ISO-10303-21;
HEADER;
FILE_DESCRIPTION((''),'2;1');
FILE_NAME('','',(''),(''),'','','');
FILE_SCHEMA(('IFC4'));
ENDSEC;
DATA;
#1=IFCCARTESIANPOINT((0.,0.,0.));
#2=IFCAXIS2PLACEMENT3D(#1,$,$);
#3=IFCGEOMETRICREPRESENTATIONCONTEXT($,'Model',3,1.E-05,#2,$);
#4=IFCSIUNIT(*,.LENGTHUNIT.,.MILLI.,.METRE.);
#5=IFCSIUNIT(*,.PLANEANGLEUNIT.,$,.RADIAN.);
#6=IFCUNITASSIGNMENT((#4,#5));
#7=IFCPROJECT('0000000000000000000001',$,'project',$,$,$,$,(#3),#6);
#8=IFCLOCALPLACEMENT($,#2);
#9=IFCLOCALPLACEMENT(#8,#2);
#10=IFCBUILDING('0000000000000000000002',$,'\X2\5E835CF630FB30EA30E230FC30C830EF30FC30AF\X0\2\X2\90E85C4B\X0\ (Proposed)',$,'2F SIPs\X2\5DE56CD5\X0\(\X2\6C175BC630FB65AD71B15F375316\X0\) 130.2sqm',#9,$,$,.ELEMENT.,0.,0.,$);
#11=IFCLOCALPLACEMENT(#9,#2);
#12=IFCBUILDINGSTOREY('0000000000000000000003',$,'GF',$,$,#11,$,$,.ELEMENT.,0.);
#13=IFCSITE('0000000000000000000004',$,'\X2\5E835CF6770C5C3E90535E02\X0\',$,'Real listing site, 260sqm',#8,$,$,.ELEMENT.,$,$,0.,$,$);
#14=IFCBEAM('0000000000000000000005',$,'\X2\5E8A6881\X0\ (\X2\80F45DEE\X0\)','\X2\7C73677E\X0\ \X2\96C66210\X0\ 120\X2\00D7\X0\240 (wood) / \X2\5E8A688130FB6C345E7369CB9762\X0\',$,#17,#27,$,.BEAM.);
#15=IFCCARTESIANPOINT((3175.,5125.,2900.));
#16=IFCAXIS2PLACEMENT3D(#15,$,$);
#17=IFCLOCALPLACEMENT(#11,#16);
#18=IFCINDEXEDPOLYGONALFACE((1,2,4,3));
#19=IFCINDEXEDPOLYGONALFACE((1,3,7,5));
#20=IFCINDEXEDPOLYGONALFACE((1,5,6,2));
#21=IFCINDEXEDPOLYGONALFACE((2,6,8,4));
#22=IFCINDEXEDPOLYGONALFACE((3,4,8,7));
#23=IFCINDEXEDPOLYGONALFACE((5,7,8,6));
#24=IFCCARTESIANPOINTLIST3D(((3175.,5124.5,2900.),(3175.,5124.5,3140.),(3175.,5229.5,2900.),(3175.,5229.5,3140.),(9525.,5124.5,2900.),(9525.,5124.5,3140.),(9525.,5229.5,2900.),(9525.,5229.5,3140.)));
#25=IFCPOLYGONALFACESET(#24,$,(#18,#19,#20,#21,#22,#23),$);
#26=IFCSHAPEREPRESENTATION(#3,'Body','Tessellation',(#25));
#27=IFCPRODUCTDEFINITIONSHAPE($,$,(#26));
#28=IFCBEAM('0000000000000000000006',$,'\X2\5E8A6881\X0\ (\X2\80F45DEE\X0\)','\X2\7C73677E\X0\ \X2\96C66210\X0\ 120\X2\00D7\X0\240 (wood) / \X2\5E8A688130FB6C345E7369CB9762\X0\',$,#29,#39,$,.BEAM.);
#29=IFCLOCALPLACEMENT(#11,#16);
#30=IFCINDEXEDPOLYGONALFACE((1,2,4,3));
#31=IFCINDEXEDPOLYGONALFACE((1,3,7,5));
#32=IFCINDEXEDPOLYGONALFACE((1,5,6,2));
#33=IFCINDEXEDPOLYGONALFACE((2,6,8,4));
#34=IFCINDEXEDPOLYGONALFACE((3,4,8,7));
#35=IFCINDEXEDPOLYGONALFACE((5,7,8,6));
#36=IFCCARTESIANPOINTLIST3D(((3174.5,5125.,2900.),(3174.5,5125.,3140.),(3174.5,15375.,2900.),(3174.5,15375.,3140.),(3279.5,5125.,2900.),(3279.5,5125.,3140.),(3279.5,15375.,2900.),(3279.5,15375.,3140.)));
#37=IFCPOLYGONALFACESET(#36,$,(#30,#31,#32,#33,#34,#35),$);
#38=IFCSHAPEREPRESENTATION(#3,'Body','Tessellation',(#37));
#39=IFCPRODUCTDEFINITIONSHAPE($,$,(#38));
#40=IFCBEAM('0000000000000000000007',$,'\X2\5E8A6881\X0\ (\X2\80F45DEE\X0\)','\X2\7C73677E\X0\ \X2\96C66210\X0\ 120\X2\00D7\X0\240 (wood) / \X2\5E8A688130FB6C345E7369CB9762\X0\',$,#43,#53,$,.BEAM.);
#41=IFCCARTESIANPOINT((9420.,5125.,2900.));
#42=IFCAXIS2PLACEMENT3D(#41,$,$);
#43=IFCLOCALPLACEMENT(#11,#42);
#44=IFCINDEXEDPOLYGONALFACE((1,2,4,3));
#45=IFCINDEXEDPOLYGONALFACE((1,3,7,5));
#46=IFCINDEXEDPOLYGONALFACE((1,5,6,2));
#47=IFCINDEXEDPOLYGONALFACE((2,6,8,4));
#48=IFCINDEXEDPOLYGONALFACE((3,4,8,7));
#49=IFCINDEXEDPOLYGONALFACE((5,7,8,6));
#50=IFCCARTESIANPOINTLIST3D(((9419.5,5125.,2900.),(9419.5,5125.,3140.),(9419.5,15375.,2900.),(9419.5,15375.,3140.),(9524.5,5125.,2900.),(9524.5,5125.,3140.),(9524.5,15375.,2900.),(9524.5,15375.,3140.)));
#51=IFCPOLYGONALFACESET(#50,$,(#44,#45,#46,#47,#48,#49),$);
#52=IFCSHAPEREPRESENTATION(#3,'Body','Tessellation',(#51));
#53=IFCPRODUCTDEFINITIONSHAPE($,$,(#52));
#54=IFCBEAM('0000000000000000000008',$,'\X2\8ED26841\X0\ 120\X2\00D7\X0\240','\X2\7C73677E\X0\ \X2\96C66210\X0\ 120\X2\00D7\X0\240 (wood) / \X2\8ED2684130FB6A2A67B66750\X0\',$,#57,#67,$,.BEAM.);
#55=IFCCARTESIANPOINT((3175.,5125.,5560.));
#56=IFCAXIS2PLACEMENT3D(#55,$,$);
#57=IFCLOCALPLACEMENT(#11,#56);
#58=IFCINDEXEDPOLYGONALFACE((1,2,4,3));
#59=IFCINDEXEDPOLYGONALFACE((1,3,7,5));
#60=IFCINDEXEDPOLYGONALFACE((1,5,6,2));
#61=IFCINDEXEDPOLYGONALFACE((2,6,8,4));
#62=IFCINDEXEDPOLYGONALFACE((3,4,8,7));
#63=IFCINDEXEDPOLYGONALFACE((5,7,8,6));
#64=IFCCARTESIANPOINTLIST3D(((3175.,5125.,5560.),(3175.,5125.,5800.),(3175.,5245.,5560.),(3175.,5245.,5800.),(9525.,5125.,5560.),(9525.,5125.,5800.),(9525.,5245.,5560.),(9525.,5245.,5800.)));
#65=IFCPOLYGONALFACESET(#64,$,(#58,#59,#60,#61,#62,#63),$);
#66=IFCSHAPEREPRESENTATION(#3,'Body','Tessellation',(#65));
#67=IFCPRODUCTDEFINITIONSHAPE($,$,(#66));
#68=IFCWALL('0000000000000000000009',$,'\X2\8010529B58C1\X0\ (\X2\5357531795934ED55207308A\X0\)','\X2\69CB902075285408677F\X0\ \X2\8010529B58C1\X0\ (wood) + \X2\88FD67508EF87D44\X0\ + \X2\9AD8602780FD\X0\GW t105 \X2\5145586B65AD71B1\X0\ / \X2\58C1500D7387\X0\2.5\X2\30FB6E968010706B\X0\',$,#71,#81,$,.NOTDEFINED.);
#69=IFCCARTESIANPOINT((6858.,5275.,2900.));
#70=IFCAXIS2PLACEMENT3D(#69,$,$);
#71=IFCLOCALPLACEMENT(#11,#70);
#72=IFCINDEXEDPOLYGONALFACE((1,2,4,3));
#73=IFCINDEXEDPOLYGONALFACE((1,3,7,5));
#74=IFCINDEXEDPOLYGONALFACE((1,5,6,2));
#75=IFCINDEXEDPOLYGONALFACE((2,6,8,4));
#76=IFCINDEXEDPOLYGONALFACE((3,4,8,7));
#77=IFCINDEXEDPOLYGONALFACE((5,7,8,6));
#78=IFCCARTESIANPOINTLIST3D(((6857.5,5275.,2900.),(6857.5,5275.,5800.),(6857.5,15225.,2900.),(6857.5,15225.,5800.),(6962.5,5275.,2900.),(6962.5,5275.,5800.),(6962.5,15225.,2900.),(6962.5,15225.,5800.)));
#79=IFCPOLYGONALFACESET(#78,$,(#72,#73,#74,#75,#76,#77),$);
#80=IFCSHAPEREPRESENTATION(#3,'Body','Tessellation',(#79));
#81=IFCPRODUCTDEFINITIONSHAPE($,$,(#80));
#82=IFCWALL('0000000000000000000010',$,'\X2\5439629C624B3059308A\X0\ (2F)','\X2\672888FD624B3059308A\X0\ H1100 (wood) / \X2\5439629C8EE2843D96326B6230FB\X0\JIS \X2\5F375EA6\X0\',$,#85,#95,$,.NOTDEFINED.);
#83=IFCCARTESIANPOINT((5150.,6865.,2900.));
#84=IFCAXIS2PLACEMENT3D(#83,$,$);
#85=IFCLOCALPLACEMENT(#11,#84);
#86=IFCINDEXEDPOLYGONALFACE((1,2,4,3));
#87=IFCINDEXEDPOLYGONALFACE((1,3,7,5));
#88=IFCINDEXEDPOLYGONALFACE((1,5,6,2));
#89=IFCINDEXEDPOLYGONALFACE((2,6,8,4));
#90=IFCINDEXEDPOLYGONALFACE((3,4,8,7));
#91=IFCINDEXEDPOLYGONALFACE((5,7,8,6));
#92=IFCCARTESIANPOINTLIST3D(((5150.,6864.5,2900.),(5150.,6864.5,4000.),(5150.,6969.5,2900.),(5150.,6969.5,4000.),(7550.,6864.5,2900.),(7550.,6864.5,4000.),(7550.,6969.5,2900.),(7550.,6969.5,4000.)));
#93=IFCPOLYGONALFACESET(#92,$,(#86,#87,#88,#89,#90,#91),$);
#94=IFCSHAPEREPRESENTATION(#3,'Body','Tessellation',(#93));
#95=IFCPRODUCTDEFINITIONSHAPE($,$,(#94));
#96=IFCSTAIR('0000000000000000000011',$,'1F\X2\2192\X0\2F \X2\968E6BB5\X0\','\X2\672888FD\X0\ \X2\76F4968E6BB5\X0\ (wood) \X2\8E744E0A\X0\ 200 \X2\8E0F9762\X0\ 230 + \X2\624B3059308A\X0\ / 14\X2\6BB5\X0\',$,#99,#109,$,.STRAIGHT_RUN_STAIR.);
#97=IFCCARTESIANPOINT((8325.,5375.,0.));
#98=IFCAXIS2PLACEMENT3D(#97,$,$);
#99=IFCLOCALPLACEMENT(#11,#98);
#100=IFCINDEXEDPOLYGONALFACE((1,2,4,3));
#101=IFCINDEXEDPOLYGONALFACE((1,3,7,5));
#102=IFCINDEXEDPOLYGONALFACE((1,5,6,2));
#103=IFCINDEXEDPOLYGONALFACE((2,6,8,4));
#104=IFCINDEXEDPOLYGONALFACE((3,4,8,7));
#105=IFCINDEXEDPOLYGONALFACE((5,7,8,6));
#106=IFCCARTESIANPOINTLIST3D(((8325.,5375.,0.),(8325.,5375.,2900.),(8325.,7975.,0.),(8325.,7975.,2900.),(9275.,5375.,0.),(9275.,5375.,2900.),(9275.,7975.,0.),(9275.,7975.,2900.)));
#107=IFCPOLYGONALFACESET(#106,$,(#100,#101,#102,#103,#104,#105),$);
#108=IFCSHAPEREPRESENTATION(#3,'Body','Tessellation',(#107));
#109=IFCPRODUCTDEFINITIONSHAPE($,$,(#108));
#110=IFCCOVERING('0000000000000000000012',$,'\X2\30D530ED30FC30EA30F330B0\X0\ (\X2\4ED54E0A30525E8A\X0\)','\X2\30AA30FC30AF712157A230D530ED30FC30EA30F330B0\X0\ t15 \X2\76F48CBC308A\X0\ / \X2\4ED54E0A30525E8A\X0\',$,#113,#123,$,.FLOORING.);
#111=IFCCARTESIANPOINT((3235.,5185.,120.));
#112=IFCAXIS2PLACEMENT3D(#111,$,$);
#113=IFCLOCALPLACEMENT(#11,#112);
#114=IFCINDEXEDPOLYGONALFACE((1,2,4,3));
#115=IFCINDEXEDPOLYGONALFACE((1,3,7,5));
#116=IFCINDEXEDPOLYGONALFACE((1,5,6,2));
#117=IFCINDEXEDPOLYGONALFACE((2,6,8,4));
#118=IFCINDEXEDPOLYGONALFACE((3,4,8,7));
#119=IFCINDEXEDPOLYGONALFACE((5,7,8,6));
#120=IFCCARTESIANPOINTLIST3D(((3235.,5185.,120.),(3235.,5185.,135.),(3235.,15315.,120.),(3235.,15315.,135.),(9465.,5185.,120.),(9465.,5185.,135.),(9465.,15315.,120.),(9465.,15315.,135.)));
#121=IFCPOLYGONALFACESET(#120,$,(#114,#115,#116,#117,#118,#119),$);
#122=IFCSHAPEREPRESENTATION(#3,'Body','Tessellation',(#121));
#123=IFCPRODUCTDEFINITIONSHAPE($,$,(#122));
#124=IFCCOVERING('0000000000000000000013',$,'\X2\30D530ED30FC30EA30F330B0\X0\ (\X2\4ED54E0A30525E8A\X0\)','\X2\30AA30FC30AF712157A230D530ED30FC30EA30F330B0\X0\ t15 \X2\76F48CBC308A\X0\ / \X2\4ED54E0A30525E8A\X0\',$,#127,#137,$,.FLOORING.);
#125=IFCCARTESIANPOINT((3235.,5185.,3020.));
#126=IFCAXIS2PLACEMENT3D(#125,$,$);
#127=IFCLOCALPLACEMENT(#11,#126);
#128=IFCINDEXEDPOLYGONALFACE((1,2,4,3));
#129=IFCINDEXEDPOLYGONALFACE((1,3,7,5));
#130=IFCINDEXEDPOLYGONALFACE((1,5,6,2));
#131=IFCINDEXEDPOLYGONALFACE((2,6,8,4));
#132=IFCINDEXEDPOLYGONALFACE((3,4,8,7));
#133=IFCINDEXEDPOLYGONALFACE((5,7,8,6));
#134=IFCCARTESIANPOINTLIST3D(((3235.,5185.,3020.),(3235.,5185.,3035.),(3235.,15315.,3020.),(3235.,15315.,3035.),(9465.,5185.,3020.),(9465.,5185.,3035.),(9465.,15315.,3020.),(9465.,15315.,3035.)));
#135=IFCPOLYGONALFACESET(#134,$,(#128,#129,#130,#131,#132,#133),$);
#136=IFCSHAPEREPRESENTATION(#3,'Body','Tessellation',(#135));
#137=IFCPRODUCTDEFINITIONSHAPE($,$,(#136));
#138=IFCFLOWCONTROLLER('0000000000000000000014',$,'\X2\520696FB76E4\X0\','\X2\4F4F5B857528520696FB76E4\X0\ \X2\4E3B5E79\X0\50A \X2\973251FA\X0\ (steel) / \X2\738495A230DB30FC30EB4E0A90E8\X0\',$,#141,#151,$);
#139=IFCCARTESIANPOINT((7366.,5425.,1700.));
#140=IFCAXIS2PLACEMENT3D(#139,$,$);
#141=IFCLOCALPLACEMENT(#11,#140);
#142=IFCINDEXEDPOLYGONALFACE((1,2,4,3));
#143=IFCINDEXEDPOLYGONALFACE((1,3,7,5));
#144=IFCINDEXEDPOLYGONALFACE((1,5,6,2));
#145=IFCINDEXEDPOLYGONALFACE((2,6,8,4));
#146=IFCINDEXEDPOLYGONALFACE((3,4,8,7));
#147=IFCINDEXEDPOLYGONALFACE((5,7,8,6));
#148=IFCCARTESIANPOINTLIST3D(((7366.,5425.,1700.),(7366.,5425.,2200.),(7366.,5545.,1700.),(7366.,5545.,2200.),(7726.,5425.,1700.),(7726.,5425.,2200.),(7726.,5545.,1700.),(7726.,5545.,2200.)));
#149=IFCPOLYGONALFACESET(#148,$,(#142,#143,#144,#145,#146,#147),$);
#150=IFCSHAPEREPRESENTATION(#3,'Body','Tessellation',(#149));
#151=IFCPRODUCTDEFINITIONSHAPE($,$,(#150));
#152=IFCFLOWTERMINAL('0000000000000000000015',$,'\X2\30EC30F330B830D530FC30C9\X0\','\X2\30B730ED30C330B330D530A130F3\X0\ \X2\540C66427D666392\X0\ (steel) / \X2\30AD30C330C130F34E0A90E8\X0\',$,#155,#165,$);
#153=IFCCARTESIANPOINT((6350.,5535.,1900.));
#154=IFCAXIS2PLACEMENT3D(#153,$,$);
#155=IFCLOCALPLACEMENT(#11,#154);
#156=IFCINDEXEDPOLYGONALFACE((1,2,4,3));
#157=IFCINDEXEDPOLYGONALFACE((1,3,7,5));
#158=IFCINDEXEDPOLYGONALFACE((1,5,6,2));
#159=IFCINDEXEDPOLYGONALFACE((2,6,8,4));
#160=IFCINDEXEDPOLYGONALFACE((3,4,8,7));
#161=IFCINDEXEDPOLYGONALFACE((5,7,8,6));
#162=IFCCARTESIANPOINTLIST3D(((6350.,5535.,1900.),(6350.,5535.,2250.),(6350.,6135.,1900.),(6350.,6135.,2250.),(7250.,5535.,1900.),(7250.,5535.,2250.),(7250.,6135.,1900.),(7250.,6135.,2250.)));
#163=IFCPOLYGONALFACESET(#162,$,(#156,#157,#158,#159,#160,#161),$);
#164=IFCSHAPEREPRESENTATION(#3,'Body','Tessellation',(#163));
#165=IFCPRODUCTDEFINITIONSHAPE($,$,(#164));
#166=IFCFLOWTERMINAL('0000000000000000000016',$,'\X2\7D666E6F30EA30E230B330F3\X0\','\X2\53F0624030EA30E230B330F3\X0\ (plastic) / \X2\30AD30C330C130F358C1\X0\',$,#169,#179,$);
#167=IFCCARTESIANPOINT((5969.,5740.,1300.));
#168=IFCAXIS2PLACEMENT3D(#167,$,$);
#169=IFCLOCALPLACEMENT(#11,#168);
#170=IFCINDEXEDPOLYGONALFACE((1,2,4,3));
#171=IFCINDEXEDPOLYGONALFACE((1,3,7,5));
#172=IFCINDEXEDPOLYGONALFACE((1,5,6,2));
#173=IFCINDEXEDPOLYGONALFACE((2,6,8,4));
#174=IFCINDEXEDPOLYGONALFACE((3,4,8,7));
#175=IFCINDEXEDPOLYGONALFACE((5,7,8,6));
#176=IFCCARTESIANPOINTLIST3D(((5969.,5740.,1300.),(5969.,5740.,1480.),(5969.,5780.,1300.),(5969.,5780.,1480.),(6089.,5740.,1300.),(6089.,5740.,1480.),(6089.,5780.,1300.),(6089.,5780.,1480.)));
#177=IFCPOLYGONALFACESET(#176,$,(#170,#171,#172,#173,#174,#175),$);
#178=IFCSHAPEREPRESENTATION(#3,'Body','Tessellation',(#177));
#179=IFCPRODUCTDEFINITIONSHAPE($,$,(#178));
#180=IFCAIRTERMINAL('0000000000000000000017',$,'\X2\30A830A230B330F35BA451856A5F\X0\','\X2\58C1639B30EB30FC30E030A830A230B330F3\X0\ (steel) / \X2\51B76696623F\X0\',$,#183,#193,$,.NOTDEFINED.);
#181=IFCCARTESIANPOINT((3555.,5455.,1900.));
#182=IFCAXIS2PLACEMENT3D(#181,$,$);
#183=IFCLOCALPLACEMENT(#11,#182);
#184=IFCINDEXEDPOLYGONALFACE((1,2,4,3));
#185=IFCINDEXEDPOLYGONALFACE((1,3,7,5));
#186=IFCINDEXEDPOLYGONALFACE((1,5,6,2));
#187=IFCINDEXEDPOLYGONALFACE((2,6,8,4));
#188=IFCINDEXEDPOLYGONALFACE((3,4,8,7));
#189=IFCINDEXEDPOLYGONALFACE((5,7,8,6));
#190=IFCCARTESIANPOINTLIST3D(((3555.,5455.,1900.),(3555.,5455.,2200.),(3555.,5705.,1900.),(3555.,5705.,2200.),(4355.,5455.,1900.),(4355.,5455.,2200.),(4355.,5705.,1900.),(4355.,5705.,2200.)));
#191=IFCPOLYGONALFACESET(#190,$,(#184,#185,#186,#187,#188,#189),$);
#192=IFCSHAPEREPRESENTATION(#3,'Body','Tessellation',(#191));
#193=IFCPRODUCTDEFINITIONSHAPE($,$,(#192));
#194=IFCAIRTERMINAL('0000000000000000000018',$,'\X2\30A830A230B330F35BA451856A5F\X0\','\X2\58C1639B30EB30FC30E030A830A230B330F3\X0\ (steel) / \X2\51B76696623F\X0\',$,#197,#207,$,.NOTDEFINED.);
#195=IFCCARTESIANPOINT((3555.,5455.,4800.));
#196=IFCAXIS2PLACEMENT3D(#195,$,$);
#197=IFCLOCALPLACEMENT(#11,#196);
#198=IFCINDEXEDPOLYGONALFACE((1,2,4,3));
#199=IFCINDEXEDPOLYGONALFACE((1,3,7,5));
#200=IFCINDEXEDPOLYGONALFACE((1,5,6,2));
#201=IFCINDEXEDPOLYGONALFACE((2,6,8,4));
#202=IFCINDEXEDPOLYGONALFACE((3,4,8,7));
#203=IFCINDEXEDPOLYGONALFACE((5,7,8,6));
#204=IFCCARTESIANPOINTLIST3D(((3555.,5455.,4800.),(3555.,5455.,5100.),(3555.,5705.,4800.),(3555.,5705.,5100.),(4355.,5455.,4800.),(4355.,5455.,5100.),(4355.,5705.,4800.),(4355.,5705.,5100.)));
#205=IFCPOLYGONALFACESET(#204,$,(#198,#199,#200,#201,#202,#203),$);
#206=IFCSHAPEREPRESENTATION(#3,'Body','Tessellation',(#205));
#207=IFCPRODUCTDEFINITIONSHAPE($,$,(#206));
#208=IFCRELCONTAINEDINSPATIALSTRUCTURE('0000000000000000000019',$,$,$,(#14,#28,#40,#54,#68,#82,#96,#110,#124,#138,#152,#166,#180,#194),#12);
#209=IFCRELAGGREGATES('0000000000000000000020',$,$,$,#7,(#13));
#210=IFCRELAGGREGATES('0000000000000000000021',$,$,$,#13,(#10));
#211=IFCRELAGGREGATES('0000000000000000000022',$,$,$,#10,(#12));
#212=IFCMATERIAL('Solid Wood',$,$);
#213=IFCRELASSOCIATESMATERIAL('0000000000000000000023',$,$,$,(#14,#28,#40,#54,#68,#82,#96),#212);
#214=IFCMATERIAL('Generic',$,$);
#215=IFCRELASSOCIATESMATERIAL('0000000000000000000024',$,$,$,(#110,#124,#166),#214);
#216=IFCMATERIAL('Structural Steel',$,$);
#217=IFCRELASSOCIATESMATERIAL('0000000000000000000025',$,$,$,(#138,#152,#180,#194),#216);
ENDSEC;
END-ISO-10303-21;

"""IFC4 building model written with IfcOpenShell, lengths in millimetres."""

from ifc_helpers import new_model, si_unit, frame, frame_2d, origin, place, context, project, spatial, rectangle, extrude, material, element, save


model = new_model("IFC4")

# Units and contexts
model_context = context("Model", 3, precision=1e-05, world=origin())
ifc_project = project(units=[si_unit("LENGTHUNIT", "METRE", prefix="MILLI"), si_unit("PLANEANGLEUNIT", "RADIAN")], contexts=[model_context])

# Site, building, storey
site_placement = place(None, origin())
site = spatial("IfcSite", under=ifc_project, at=site_placement, Name="広島県尾道市", ObjectType="Real listing site, 260sqm", CompositionType="ELEMENT", RefElevation=0.0)
building_placement = place(site_placement, origin())
building = spatial("IfcBuilding", under=site, at=building_placement, Name="広島・リモートワーク2部屋 (Proposed)", ObjectType="2F SIPs工法(気密・断熱強化) 130.2sqm", CompositionType="ELEMENT", ElevationOfRefHeight=0.0, ElevationOfTerrain=0.0)
storey_placement = place(building_placement, origin())
storey = spatial("IfcBuildingStorey", under=building, at=storey_placement, Name="GF", CompositionType="ELEMENT", Elevation=0.0)

# Shared definitions
ifc_material_1 = material(Name="Solid Wood")

# Beams
beam_1_placement = place(storey_placement, frame((3175.0, 5125.0, 2900.0)))
element("IfcBeam", 1, at=beam_1_placement, inside=storey, material=ifc_material_1, Name="床梁 (胴差)", Description="米松 集成 120×240 (wood) / 床梁・水平構面", PredefinedType="BEAM", context=model_context, shape_type="SweptSolid", body=[
    extrude(rectangle(XDim=6350.0, YDim=105.0, at=frame_2d((3175.0, 52.0))), frame((3175.0, 5125.0, 2900.0)), (0.0, 0.0, 1.0), 240.0),
])
beam_2_placement = place(storey_placement, frame((3175.0, 5125.0, 2900.0)))
element("IfcBeam", 2, at=beam_2_placement, inside=storey, material=ifc_material_1, Name="床梁 (胴差)", Description="米松 集成 120×240 (wood) / 床梁・水平構面", PredefinedType="BEAM", context=model_context, shape_type="SweptSolid", body=[
    extrude(rectangle(XDim=105.0, YDim=10250.0, at=frame_2d((52.0, 5125.0))), frame((3175.0, 5125.0, 2900.0)), (0.0, 0.0, 1.0), 240.0),
])
beam_3_placement = place(storey_placement, frame((9420.0, 5125.0, 2900.0)))
element("IfcBeam", 3, at=beam_3_placement, inside=storey, material=ifc_material_1, Name="床梁 (胴差)", Description="米松 集成 120×240 (wood) / 床梁・水平構面", PredefinedType="BEAM", context=model_context, shape_type="SweptSolid", body=[
    extrude(rectangle(XDim=105.0, YDim=10250.0, at=frame_2d((52.0, 5125.0))), frame((9420.0, 5125.0, 2900.0)), (0.0, 0.0, 1.0), 240.0),
])
beam_4_placement = place(storey_placement, frame((3175.0, 5125.0, 5560.0)))
element("IfcBeam", 4, at=beam_4_placement, inside=storey, material=ifc_material_1, Name="軒桁 120×240", Description="米松 集成 120×240 (wood) / 軒桁・横架材", PredefinedType="BEAM", context=model_context, shape_type="SweptSolid", body=[
    extrude(rectangle(XDim=6350.0, YDim=120.0, at=frame_2d((3175.0, 60.0))), frame((3175.0, 5125.0, 5560.0)), (0.0, 0.0, 1.0), 240.0),
])

# Walls
wall_1_placement = place(storey_placement, frame((6858.0, 5275.0, 2900.0)))
element("IfcWall", 5, at=wall_1_placement, inside=storey, material=ifc_material_1, Name="耐力壁 (南北間仕切り)", Description="構造用合板 耐力壁 (wood) + 製材軸組 + 高性能GW t105 充填断熱 / 壁倍率2.5・準耐火", PredefinedType="NOTDEFINED", context=model_context, shape_type="SweptSolid", body=[
    extrude(rectangle(XDim=105.0, YDim=9950.0, at=frame_2d((52.0, 4975.0))), frame((6858.0, 5275.0, 2900.0)), (0.0, 0.0, 1.0), 2900.0),
])
wall_2_placement = place(storey_placement, frame((5150.0, 6865.0, 2900.0)))
element("IfcWall", 6, at=wall_2_placement, inside=storey, material=ifc_material_1, Name="吹抜手すり (2F)", Description="木製手すり H1100 (wood) / 吹抜転落防止・JIS 強度", PredefinedType="NOTDEFINED", context=model_context, shape_type="SweptSolid", body=[
    extrude(rectangle(XDim=2400.0, YDim=105.0, at=frame_2d((1200.0, 52.0))), frame((5150.0, 6865.0, 2900.0)), (0.0, 0.0, 1.0), 1100.0),
])

# Stair
stair_placement = place(storey_placement, frame((8325.0, 5375.0, 0.0)))
element("IfcStair", 7, at=stair_placement, inside=storey, material=ifc_material_1, Name="1F→2F 階段", Description="木製 直階段 (wood) 蹴上 200 踏面 230 + 手すり / 14段", PredefinedType="STRAIGHT_RUN_STAIR", context=model_context, shape_type="SweptSolid", body=[
    extrude(rectangle(XDim=950.0, YDim=2600.0, at=frame_2d((475.0, 1300.0))), frame((8325.0, 5375.0, 0.0)), (0.0, 0.0, 1.0), 2900.0),
])

# Coverings
ifc_material_2 = material(Name="Generic")
covering_1_placement = place(storey_placement, frame((3235.0, 5185.0, 120.0)))
element("IfcCovering", 8, at=covering_1_placement, inside=storey, material=ifc_material_2, Name="フローリング (仕上げ床)", Description="オーク無垢フローリング t15 直貼り / 仕上げ床", PredefinedType="FLOORING", context=model_context, shape_type="SweptSolid", body=[
    extrude(rectangle(XDim=6230.0, YDim=10130.0, at=frame_2d((3115.0, 5065.0))), frame((3235.0, 5185.0, 120.0)), (0.0, 0.0, 1.0), 15.0),
])
covering_2_placement = place(storey_placement, frame((3235.0, 5185.0, 3020.0)))
element("IfcCovering", 9, at=covering_2_placement, inside=storey, material=ifc_material_2, Name="フローリング (仕上げ床)", Description="オーク無垢フローリング t15 直貼り / 仕上げ床", PredefinedType="FLOORING", context=model_context, shape_type="SweptSolid", body=[
    extrude(rectangle(XDim=6230.0, YDim=10130.0, at=frame_2d((3115.0, 5065.0))), frame((3235.0, 5185.0, 3020.0)), (0.0, 0.0, 1.0), 15.0),
])

# Flow controller
ifc_material_3 = material(Name="Structural Steel")
flow_controller_placement = place(storey_placement, frame((7366.0, 5425.0, 1700.0)))
element("IfcFlowController", 10, at=flow_controller_placement, inside=storey, material=ifc_material_3, Name="分電盤", Description="住宅用分電盤 主幹50A 露出 (steel) / 玄関ホール上部", context=model_context, shape_type="SweptSolid", body=[
    extrude(rectangle(XDim=360.0, YDim=120.0, at=frame_2d((180.0, 60.0))), frame((7366.0, 5425.0, 1700.0)), (0.0, 0.0, 1.0), 500.0),
])

# Flow terminals
flow_terminal_1_placement = place(storey_placement, frame((6350.0, 5535.0, 1900.0)))
element("IfcFlowTerminal", 11, at=flow_terminal_1_placement, inside=storey, material=ifc_material_3, Name="レンジフード", Description="シロッコファン 同時給排 (steel) / キッチン上部", context=model_context, shape_type="SweptSolid", body=[
    extrude(rectangle(XDim=900.0, YDim=600.0, at=frame_2d((450.0, 300.0))), frame((6350.0, 5535.0, 1900.0)), (0.0, 0.0, 1.0), 350.0),
])
flow_terminal_2_placement = place(storey_placement, frame((5969.0, 5740.0, 1300.0)))
element("IfcFlowTerminal", 12, at=flow_terminal_2_placement, inside=storey, material=ifc_material_2, Name="給湯リモコン", Description="台所リモコン (plastic) / キッチン壁", context=model_context, shape_type="SweptSolid", body=[
    extrude(rectangle(XDim=120.0, YDim=40.0, at=frame_2d((60.0, 20.0))), frame((5969.0, 5740.0, 1300.0)), (0.0, 0.0, 1.0), 180.0),
])

# Air terminals
air_terminal_1_placement = place(storey_placement, frame((3555.0, 5455.0, 1900.0)))
element("IfcAirTerminal", 13, at=air_terminal_1_placement, inside=storey, material=ifc_material_3, Name="エアコン室内機", Description="壁掛ルームエアコン (steel) / 冷暖房", PredefinedType="NOTDEFINED", context=model_context, shape_type="SweptSolid", body=[
    extrude(rectangle(XDim=800.0, YDim=250.0, at=frame_2d((400.0, 125.0))), frame((3555.0, 5455.0, 1900.0)), (0.0, 0.0, 1.0), 300.0),
])
air_terminal_2_placement = place(storey_placement, frame((3555.0, 5455.0, 4800.0)))
element("IfcAirTerminal", 14, at=air_terminal_2_placement, inside=storey, material=ifc_material_3, Name="エアコン室内機", Description="壁掛ルームエアコン (steel) / 冷暖房", PredefinedType="NOTDEFINED", context=model_context, shape_type="SweptSolid", body=[
    extrude(rectangle(XDim=800.0, YDim=250.0, at=frame_2d((400.0, 125.0))), frame((3555.0, 5455.0, 4800.0)), (0.0, 0.0, 1.0), 300.0),
])

save(model, "model.ifc")
